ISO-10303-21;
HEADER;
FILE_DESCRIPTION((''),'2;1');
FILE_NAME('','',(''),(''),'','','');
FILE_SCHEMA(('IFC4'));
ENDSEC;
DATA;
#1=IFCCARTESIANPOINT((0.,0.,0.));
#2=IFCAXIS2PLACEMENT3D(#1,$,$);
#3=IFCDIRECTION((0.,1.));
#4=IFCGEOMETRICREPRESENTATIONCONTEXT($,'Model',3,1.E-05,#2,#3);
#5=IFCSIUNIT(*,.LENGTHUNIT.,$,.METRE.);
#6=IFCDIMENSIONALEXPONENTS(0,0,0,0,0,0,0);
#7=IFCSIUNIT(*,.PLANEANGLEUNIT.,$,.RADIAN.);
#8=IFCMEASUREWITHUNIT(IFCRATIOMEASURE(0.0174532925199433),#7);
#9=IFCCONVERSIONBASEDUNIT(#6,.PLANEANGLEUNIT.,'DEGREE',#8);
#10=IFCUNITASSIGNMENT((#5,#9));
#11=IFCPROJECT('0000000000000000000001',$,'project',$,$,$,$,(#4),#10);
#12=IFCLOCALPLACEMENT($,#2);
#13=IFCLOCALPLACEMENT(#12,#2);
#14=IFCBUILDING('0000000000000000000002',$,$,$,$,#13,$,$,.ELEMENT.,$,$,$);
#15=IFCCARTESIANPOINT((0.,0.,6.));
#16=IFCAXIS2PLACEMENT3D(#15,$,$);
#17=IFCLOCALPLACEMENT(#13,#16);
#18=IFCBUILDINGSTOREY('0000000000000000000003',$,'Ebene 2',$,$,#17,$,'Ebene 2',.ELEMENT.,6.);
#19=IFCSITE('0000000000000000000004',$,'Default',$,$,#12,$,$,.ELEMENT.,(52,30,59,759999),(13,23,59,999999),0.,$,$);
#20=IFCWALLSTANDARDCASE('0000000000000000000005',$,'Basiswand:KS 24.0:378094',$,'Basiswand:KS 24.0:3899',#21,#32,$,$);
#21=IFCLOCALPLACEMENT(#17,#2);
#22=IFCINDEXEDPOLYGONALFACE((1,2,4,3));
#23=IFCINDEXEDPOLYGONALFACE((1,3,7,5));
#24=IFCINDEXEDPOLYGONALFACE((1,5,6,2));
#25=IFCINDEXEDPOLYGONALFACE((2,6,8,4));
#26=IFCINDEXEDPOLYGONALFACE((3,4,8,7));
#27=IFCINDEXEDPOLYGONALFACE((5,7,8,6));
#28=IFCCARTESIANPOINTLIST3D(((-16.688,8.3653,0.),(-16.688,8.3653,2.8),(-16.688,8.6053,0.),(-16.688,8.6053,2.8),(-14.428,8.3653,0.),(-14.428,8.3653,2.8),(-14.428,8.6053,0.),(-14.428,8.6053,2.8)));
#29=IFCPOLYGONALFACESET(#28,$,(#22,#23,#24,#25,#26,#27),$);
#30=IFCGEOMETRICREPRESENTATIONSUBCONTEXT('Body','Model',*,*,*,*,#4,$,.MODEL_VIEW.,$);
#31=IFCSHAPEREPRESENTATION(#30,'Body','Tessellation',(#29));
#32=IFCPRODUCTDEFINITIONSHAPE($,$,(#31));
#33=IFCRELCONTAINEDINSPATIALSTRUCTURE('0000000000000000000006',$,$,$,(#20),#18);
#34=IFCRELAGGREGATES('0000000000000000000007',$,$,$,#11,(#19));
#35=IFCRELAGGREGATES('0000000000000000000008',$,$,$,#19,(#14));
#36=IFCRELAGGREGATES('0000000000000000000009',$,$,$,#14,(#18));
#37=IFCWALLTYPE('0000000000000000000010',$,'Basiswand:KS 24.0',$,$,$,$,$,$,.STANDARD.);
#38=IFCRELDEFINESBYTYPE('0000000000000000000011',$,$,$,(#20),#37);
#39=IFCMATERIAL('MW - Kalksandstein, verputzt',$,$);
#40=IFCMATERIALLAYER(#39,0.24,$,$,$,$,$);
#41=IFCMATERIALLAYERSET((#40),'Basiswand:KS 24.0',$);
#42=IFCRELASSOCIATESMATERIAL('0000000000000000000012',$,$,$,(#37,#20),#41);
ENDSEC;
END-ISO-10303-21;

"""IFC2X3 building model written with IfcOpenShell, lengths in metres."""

from ifc_helpers import new_model, entity, si_unit, converted_unit, direction, frame, frame_2d, origin, place, context, subcontext, project, spatial, polyline, rectangle, extrude, clip, bounded_halfspace, material, layer, layer_set, layer_usage, type_object, element, save


model = new_model("IFC2X3")

# Units and contexts
model_context = context("Model", 3, precision=1e-05, world=origin(), true_north=direction((0.0, 1.0)))
body_context = subcontext(model_context, "Body", "Model", "MODEL_VIEW")
ifc_project = project(units=[si_unit("LENGTHUNIT", "METRE"), converted_unit("PLANEANGLEUNIT", "DEGREE", entity("IfcRatioMeasure", 0.0174532925199433), si_unit("PLANEANGLEUNIT", "RADIAN"), dimensions=[0, 0, 0, 0, 0, 0, 0])], contexts=[model_context])

# Site, building, storey
site_placement = place(None, origin())
site = spatial("IfcSite", under=ifc_project, at=site_placement, Name="Default", CompositionType="ELEMENT", RefLatitude=(52, 30, 59, 759999), RefLongitude=(13, 23, 59, 999999), RefElevation=0.0)
building_placement = place(site_placement, origin())
building = spatial("IfcBuilding", under=site, at=building_placement, CompositionType="ELEMENT")
storey_placement = place(building_placement, frame((0.0, 0.0, 6.0)))
storey = spatial("IfcBuildingStorey", under=building, at=storey_placement, Name="Ebene 2", LongName="Ebene 2", CompositionType="ELEMENT", Elevation=6.0)

# Shared definitions
ifc_material_1 = material(Name="MW - Kalksandstein, verputzt")
ifc_layer_1 = layer(ifc_material_1, 0.24)
ifc_layer_set_1 = layer_set([ifc_layer_1], Name="Basiswand:KS 24.0")
wall_type_1 = type_object("IfcWallType", Name="Basiswand:KS 24.0", PredefinedType="STANDARD", material=ifc_layer_set_1)

# Wall
ifc_layer_usage_1 = layer_usage(ifc_layer_set_1, "AXIS2", "NEGATIVE", 0.12)
wall_1_placement = place(storey_placement, frame((-16.688, 8.4853, 0.0)))
element("IfcWallStandardCase", 1, at=wall_1_placement, inside=storey, type_object=wall_type_1, material=ifc_layer_usage_1, Name="Basiswand:KS 24.0:378094", ObjectType="Basiswand:KS 24.0:3899", context=body_context, shape_type="Clipping", body=[
    clip(extrude(rectangle(XDim=2.26, YDim=0.24, at=frame_2d((1.13, 0.0), x_axis=(-1.0, 0.0))), origin(), (0.0, 0.0, 1.0), 2.8), bounded_halfspace(frame((0.0, -0.12, 2.8), z_axis=(0.0, 0.0, -1.0), x_axis=(-1.0, 0.0, 0.0)), True, frame((0.0, -0.12, 2.8)), polyline([(0.0, 0.0), (2.26, 0.0), (2.26, 0.24), (0.0, 0.24), (0.0, 0.0)]))),
])

save(model, "model.ifc")
